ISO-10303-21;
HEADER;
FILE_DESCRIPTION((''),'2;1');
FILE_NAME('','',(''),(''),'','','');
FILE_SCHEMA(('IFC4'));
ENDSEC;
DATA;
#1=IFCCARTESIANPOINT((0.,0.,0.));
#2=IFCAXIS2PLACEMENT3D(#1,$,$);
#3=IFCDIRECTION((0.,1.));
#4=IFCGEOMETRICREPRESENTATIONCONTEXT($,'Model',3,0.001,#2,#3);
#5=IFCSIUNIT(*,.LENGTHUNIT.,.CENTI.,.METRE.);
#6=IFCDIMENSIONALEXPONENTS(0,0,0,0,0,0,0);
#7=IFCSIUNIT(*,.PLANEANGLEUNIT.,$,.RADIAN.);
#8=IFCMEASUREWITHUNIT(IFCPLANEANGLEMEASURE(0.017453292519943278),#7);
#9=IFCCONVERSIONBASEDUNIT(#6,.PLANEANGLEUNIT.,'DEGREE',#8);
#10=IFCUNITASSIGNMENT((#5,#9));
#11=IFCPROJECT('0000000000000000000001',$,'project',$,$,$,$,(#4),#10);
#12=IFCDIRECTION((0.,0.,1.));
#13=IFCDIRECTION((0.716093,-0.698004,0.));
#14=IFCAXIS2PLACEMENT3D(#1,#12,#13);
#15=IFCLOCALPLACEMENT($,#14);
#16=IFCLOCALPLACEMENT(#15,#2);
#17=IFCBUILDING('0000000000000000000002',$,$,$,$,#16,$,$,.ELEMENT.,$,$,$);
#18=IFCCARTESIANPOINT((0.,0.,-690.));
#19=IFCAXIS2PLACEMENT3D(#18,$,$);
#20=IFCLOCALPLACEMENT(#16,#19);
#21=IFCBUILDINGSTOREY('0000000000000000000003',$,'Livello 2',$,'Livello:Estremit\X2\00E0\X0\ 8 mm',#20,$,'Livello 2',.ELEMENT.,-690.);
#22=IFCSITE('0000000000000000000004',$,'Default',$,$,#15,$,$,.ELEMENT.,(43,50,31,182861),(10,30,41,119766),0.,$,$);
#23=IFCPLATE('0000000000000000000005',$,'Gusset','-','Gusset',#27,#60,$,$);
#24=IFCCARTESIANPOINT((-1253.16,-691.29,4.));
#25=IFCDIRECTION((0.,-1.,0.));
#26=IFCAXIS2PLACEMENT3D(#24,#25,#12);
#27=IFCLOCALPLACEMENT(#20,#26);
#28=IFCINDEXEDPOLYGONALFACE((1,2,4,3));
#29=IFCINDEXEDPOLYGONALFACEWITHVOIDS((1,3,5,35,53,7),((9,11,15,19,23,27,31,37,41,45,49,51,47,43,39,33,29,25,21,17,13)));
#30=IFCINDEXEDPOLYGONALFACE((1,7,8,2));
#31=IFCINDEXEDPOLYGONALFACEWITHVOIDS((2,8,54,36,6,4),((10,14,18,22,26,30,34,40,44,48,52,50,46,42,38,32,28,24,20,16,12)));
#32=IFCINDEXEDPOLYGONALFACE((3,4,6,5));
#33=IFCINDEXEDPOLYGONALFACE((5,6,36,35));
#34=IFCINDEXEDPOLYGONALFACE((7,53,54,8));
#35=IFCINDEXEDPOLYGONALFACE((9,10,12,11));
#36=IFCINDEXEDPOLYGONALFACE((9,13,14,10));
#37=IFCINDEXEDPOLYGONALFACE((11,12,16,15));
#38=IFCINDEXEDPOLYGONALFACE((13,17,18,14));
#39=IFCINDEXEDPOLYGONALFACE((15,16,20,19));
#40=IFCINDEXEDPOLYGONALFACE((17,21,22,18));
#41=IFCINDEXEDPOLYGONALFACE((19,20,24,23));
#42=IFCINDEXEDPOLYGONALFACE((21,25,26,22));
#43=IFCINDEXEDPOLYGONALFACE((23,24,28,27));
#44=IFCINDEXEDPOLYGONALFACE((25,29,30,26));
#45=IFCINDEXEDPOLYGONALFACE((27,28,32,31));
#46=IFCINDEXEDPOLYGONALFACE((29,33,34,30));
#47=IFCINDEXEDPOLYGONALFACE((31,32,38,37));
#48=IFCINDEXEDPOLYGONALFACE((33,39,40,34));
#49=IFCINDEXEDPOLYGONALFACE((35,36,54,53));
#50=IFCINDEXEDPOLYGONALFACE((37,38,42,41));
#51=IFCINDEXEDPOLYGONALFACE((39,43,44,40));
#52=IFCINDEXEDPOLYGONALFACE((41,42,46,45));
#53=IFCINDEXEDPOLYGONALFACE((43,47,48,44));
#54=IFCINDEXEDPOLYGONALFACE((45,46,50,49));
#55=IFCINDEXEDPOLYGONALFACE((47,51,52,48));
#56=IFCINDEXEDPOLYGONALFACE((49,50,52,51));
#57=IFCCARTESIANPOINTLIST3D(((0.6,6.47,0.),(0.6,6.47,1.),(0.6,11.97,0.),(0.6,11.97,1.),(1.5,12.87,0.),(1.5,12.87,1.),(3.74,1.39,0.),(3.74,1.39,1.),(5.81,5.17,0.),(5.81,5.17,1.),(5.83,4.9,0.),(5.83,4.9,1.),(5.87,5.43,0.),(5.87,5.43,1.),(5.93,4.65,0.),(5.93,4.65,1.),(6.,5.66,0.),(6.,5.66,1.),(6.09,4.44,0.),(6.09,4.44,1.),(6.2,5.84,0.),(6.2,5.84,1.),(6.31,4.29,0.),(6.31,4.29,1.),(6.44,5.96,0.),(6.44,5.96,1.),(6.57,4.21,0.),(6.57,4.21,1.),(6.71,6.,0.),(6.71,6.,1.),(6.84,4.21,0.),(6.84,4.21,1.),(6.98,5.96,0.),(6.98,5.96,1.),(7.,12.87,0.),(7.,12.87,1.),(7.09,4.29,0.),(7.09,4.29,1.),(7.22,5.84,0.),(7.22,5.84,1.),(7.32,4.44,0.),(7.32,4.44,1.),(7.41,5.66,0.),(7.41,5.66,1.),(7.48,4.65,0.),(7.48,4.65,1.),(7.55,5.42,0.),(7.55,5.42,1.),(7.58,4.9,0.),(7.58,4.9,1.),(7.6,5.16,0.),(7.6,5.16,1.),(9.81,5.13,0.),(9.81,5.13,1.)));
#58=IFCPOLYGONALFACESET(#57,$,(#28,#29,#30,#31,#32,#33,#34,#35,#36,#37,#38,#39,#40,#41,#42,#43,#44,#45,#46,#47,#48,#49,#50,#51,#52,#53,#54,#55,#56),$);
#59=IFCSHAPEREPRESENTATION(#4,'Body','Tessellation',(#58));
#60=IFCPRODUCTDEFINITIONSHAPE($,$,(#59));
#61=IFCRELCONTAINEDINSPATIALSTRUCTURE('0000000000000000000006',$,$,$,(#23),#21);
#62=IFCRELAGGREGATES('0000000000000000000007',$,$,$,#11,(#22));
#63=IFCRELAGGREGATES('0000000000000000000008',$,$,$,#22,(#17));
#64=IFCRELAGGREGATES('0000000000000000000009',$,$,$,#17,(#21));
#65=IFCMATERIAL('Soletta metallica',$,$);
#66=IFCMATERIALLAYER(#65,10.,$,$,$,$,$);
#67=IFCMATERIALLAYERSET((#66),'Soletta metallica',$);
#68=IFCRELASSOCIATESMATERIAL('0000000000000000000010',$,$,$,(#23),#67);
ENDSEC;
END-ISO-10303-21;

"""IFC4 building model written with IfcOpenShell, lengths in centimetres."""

from ifc_helpers import new_model, entity, si_unit, converted_unit, point, direction, frame, frame_2d, origin, origin_with_axes, origin_2d_with_axis, place, context, project, spatial, polyline, circle_curve, line_curve, trimmed, segment, composite_curve, circle, outline, extrude, material, layer, layer_set, element, save


model = new_model("IFC4")

# Units and contexts
model_context = context("Model", 3, precision=0.001, world=origin(), true_north=direction((0.0, 1.0)))
ifc_project = project(units=[si_unit("LENGTHUNIT", "METRE", prefix="CENTI"), converted_unit("PLANEANGLEUNIT", "DEGREE", entity("IfcPlaneAngleMeasure", 0.017453292519943278), si_unit("PLANEANGLEUNIT", "RADIAN"), dimensions=[0, 0, 0, 0, 0, 0, 0])], contexts=[model_context])

# Site, building, storey
site_placement = place(None, frame((0.0, 0.0, 0.0), z_axis=(0.0, 0.0, 1.0), x_axis=(0.716093, -0.698004, 0.0)))
site = spatial("IfcSite", under=ifc_project, at=site_placement, Name="Default", CompositionType="ELEMENT", RefLatitude=(43, 50, 31, 182861), RefLongitude=(10, 30, 41, 119766), RefElevation=0.0)
building_placement = place(site_placement, origin())
building = spatial("IfcBuilding", under=site, at=building_placement, CompositionType="ELEMENT")
storey_placement = place(building_placement, frame((0.0, 0.0, -690.0)))
storey = spatial("IfcBuildingStorey", under=building, at=storey_placement, Name="Livello 2", ObjectType="Livello:Estremità 8 mm", LongName="Livello 2", CompositionType="ELEMENT", Elevation=-690.0)

# Plate, openings
ifc_material_1 = material(Name="Soletta metallica")
ifc_layer = layer(ifc_material_1, 10.0)
ifc_layer_set = layer_set([ifc_layer], Name="Soletta metallica")
plate_1_placement = place(storey_placement, frame((-1253.16, -691.29, 4.0), z_axis=(0.0, -1.0, 0.0), x_axis=(0.0, 0.0, 1.0)))
plate_1 = element("IfcPlate", 1, at=plate_1_placement, inside=storey, material=ifc_layer_set, Name="Gusset", Description="-", ObjectType="Gusset", context=model_context, shape_type="SweptSolid", body=[
    extrude(outline(polyline([(0.6, 6.47), (3.74, 1.39), (9.81, 5.13), (7.0, 12.87), (0.6, 12.87), (0.6, 6.47)])), origin_with_axes(), (0.0, 0.0, 1.0), 1.0),
])
opening_1_placement = place(plate_1_placement, frame((0.0, 0.0, 0.0), z_axis=(0.0, 0.0, 1.0), x_axis=(1.0, 0.0, 0.0)))
element("IfcOpeningElement", 2, at=opening_1_placement, cuts=plate_1, ObjectType="Opening", context=model_context, shape_type="SweptSolid", body=[
    extrude(outline(composite_curve([segment(trimmed(line_curve((0.6, 12.87), (0.0, -1.0), 0.9), [point((0.6, 12.87))], [point((0.6, 11.97))], True, "CARTESIAN"), True, "CONTINUOUS"), segment(trimmed(circle_curve(frame_2d((1.5, 11.97), x_axis=(-1.0, 0.0)), 0.9), [point((0.6, 11.97))], [point((1.5, 12.87))], False, "CARTESIAN"), True, "CONTINUOUS"), segment(trimmed(line_curve((1.5, 12.87), (-1.0, 0.0), 0.9), [point((1.5, 12.87))], [point((0.6, 12.87))], True, "CARTESIAN"), True, "CONTINUOUS")], self_intersect="UNKNOWN")), origin(), (0.0, 0.0, 1.0), 1.0),
])
opening_2_placement = place(plate_1_placement, frame((6.71, 5.1, 1.05), z_axis=(0.0, 0.0, -1.0), x_axis=(-0.56027, 0.82831, 0.0)))
element("IfcOpeningElement", 3, at=opening_2_placement, cuts=plate_1, ObjectType="Opening", context=model_context, shape_type="SweptSolid", body=[
    extrude(circle(Radius=0.9, at=origin_2d_with_axis()), origin(), (0.0, 0.0, 1.0), 1.1),
])

save(model, "model.ifc")
